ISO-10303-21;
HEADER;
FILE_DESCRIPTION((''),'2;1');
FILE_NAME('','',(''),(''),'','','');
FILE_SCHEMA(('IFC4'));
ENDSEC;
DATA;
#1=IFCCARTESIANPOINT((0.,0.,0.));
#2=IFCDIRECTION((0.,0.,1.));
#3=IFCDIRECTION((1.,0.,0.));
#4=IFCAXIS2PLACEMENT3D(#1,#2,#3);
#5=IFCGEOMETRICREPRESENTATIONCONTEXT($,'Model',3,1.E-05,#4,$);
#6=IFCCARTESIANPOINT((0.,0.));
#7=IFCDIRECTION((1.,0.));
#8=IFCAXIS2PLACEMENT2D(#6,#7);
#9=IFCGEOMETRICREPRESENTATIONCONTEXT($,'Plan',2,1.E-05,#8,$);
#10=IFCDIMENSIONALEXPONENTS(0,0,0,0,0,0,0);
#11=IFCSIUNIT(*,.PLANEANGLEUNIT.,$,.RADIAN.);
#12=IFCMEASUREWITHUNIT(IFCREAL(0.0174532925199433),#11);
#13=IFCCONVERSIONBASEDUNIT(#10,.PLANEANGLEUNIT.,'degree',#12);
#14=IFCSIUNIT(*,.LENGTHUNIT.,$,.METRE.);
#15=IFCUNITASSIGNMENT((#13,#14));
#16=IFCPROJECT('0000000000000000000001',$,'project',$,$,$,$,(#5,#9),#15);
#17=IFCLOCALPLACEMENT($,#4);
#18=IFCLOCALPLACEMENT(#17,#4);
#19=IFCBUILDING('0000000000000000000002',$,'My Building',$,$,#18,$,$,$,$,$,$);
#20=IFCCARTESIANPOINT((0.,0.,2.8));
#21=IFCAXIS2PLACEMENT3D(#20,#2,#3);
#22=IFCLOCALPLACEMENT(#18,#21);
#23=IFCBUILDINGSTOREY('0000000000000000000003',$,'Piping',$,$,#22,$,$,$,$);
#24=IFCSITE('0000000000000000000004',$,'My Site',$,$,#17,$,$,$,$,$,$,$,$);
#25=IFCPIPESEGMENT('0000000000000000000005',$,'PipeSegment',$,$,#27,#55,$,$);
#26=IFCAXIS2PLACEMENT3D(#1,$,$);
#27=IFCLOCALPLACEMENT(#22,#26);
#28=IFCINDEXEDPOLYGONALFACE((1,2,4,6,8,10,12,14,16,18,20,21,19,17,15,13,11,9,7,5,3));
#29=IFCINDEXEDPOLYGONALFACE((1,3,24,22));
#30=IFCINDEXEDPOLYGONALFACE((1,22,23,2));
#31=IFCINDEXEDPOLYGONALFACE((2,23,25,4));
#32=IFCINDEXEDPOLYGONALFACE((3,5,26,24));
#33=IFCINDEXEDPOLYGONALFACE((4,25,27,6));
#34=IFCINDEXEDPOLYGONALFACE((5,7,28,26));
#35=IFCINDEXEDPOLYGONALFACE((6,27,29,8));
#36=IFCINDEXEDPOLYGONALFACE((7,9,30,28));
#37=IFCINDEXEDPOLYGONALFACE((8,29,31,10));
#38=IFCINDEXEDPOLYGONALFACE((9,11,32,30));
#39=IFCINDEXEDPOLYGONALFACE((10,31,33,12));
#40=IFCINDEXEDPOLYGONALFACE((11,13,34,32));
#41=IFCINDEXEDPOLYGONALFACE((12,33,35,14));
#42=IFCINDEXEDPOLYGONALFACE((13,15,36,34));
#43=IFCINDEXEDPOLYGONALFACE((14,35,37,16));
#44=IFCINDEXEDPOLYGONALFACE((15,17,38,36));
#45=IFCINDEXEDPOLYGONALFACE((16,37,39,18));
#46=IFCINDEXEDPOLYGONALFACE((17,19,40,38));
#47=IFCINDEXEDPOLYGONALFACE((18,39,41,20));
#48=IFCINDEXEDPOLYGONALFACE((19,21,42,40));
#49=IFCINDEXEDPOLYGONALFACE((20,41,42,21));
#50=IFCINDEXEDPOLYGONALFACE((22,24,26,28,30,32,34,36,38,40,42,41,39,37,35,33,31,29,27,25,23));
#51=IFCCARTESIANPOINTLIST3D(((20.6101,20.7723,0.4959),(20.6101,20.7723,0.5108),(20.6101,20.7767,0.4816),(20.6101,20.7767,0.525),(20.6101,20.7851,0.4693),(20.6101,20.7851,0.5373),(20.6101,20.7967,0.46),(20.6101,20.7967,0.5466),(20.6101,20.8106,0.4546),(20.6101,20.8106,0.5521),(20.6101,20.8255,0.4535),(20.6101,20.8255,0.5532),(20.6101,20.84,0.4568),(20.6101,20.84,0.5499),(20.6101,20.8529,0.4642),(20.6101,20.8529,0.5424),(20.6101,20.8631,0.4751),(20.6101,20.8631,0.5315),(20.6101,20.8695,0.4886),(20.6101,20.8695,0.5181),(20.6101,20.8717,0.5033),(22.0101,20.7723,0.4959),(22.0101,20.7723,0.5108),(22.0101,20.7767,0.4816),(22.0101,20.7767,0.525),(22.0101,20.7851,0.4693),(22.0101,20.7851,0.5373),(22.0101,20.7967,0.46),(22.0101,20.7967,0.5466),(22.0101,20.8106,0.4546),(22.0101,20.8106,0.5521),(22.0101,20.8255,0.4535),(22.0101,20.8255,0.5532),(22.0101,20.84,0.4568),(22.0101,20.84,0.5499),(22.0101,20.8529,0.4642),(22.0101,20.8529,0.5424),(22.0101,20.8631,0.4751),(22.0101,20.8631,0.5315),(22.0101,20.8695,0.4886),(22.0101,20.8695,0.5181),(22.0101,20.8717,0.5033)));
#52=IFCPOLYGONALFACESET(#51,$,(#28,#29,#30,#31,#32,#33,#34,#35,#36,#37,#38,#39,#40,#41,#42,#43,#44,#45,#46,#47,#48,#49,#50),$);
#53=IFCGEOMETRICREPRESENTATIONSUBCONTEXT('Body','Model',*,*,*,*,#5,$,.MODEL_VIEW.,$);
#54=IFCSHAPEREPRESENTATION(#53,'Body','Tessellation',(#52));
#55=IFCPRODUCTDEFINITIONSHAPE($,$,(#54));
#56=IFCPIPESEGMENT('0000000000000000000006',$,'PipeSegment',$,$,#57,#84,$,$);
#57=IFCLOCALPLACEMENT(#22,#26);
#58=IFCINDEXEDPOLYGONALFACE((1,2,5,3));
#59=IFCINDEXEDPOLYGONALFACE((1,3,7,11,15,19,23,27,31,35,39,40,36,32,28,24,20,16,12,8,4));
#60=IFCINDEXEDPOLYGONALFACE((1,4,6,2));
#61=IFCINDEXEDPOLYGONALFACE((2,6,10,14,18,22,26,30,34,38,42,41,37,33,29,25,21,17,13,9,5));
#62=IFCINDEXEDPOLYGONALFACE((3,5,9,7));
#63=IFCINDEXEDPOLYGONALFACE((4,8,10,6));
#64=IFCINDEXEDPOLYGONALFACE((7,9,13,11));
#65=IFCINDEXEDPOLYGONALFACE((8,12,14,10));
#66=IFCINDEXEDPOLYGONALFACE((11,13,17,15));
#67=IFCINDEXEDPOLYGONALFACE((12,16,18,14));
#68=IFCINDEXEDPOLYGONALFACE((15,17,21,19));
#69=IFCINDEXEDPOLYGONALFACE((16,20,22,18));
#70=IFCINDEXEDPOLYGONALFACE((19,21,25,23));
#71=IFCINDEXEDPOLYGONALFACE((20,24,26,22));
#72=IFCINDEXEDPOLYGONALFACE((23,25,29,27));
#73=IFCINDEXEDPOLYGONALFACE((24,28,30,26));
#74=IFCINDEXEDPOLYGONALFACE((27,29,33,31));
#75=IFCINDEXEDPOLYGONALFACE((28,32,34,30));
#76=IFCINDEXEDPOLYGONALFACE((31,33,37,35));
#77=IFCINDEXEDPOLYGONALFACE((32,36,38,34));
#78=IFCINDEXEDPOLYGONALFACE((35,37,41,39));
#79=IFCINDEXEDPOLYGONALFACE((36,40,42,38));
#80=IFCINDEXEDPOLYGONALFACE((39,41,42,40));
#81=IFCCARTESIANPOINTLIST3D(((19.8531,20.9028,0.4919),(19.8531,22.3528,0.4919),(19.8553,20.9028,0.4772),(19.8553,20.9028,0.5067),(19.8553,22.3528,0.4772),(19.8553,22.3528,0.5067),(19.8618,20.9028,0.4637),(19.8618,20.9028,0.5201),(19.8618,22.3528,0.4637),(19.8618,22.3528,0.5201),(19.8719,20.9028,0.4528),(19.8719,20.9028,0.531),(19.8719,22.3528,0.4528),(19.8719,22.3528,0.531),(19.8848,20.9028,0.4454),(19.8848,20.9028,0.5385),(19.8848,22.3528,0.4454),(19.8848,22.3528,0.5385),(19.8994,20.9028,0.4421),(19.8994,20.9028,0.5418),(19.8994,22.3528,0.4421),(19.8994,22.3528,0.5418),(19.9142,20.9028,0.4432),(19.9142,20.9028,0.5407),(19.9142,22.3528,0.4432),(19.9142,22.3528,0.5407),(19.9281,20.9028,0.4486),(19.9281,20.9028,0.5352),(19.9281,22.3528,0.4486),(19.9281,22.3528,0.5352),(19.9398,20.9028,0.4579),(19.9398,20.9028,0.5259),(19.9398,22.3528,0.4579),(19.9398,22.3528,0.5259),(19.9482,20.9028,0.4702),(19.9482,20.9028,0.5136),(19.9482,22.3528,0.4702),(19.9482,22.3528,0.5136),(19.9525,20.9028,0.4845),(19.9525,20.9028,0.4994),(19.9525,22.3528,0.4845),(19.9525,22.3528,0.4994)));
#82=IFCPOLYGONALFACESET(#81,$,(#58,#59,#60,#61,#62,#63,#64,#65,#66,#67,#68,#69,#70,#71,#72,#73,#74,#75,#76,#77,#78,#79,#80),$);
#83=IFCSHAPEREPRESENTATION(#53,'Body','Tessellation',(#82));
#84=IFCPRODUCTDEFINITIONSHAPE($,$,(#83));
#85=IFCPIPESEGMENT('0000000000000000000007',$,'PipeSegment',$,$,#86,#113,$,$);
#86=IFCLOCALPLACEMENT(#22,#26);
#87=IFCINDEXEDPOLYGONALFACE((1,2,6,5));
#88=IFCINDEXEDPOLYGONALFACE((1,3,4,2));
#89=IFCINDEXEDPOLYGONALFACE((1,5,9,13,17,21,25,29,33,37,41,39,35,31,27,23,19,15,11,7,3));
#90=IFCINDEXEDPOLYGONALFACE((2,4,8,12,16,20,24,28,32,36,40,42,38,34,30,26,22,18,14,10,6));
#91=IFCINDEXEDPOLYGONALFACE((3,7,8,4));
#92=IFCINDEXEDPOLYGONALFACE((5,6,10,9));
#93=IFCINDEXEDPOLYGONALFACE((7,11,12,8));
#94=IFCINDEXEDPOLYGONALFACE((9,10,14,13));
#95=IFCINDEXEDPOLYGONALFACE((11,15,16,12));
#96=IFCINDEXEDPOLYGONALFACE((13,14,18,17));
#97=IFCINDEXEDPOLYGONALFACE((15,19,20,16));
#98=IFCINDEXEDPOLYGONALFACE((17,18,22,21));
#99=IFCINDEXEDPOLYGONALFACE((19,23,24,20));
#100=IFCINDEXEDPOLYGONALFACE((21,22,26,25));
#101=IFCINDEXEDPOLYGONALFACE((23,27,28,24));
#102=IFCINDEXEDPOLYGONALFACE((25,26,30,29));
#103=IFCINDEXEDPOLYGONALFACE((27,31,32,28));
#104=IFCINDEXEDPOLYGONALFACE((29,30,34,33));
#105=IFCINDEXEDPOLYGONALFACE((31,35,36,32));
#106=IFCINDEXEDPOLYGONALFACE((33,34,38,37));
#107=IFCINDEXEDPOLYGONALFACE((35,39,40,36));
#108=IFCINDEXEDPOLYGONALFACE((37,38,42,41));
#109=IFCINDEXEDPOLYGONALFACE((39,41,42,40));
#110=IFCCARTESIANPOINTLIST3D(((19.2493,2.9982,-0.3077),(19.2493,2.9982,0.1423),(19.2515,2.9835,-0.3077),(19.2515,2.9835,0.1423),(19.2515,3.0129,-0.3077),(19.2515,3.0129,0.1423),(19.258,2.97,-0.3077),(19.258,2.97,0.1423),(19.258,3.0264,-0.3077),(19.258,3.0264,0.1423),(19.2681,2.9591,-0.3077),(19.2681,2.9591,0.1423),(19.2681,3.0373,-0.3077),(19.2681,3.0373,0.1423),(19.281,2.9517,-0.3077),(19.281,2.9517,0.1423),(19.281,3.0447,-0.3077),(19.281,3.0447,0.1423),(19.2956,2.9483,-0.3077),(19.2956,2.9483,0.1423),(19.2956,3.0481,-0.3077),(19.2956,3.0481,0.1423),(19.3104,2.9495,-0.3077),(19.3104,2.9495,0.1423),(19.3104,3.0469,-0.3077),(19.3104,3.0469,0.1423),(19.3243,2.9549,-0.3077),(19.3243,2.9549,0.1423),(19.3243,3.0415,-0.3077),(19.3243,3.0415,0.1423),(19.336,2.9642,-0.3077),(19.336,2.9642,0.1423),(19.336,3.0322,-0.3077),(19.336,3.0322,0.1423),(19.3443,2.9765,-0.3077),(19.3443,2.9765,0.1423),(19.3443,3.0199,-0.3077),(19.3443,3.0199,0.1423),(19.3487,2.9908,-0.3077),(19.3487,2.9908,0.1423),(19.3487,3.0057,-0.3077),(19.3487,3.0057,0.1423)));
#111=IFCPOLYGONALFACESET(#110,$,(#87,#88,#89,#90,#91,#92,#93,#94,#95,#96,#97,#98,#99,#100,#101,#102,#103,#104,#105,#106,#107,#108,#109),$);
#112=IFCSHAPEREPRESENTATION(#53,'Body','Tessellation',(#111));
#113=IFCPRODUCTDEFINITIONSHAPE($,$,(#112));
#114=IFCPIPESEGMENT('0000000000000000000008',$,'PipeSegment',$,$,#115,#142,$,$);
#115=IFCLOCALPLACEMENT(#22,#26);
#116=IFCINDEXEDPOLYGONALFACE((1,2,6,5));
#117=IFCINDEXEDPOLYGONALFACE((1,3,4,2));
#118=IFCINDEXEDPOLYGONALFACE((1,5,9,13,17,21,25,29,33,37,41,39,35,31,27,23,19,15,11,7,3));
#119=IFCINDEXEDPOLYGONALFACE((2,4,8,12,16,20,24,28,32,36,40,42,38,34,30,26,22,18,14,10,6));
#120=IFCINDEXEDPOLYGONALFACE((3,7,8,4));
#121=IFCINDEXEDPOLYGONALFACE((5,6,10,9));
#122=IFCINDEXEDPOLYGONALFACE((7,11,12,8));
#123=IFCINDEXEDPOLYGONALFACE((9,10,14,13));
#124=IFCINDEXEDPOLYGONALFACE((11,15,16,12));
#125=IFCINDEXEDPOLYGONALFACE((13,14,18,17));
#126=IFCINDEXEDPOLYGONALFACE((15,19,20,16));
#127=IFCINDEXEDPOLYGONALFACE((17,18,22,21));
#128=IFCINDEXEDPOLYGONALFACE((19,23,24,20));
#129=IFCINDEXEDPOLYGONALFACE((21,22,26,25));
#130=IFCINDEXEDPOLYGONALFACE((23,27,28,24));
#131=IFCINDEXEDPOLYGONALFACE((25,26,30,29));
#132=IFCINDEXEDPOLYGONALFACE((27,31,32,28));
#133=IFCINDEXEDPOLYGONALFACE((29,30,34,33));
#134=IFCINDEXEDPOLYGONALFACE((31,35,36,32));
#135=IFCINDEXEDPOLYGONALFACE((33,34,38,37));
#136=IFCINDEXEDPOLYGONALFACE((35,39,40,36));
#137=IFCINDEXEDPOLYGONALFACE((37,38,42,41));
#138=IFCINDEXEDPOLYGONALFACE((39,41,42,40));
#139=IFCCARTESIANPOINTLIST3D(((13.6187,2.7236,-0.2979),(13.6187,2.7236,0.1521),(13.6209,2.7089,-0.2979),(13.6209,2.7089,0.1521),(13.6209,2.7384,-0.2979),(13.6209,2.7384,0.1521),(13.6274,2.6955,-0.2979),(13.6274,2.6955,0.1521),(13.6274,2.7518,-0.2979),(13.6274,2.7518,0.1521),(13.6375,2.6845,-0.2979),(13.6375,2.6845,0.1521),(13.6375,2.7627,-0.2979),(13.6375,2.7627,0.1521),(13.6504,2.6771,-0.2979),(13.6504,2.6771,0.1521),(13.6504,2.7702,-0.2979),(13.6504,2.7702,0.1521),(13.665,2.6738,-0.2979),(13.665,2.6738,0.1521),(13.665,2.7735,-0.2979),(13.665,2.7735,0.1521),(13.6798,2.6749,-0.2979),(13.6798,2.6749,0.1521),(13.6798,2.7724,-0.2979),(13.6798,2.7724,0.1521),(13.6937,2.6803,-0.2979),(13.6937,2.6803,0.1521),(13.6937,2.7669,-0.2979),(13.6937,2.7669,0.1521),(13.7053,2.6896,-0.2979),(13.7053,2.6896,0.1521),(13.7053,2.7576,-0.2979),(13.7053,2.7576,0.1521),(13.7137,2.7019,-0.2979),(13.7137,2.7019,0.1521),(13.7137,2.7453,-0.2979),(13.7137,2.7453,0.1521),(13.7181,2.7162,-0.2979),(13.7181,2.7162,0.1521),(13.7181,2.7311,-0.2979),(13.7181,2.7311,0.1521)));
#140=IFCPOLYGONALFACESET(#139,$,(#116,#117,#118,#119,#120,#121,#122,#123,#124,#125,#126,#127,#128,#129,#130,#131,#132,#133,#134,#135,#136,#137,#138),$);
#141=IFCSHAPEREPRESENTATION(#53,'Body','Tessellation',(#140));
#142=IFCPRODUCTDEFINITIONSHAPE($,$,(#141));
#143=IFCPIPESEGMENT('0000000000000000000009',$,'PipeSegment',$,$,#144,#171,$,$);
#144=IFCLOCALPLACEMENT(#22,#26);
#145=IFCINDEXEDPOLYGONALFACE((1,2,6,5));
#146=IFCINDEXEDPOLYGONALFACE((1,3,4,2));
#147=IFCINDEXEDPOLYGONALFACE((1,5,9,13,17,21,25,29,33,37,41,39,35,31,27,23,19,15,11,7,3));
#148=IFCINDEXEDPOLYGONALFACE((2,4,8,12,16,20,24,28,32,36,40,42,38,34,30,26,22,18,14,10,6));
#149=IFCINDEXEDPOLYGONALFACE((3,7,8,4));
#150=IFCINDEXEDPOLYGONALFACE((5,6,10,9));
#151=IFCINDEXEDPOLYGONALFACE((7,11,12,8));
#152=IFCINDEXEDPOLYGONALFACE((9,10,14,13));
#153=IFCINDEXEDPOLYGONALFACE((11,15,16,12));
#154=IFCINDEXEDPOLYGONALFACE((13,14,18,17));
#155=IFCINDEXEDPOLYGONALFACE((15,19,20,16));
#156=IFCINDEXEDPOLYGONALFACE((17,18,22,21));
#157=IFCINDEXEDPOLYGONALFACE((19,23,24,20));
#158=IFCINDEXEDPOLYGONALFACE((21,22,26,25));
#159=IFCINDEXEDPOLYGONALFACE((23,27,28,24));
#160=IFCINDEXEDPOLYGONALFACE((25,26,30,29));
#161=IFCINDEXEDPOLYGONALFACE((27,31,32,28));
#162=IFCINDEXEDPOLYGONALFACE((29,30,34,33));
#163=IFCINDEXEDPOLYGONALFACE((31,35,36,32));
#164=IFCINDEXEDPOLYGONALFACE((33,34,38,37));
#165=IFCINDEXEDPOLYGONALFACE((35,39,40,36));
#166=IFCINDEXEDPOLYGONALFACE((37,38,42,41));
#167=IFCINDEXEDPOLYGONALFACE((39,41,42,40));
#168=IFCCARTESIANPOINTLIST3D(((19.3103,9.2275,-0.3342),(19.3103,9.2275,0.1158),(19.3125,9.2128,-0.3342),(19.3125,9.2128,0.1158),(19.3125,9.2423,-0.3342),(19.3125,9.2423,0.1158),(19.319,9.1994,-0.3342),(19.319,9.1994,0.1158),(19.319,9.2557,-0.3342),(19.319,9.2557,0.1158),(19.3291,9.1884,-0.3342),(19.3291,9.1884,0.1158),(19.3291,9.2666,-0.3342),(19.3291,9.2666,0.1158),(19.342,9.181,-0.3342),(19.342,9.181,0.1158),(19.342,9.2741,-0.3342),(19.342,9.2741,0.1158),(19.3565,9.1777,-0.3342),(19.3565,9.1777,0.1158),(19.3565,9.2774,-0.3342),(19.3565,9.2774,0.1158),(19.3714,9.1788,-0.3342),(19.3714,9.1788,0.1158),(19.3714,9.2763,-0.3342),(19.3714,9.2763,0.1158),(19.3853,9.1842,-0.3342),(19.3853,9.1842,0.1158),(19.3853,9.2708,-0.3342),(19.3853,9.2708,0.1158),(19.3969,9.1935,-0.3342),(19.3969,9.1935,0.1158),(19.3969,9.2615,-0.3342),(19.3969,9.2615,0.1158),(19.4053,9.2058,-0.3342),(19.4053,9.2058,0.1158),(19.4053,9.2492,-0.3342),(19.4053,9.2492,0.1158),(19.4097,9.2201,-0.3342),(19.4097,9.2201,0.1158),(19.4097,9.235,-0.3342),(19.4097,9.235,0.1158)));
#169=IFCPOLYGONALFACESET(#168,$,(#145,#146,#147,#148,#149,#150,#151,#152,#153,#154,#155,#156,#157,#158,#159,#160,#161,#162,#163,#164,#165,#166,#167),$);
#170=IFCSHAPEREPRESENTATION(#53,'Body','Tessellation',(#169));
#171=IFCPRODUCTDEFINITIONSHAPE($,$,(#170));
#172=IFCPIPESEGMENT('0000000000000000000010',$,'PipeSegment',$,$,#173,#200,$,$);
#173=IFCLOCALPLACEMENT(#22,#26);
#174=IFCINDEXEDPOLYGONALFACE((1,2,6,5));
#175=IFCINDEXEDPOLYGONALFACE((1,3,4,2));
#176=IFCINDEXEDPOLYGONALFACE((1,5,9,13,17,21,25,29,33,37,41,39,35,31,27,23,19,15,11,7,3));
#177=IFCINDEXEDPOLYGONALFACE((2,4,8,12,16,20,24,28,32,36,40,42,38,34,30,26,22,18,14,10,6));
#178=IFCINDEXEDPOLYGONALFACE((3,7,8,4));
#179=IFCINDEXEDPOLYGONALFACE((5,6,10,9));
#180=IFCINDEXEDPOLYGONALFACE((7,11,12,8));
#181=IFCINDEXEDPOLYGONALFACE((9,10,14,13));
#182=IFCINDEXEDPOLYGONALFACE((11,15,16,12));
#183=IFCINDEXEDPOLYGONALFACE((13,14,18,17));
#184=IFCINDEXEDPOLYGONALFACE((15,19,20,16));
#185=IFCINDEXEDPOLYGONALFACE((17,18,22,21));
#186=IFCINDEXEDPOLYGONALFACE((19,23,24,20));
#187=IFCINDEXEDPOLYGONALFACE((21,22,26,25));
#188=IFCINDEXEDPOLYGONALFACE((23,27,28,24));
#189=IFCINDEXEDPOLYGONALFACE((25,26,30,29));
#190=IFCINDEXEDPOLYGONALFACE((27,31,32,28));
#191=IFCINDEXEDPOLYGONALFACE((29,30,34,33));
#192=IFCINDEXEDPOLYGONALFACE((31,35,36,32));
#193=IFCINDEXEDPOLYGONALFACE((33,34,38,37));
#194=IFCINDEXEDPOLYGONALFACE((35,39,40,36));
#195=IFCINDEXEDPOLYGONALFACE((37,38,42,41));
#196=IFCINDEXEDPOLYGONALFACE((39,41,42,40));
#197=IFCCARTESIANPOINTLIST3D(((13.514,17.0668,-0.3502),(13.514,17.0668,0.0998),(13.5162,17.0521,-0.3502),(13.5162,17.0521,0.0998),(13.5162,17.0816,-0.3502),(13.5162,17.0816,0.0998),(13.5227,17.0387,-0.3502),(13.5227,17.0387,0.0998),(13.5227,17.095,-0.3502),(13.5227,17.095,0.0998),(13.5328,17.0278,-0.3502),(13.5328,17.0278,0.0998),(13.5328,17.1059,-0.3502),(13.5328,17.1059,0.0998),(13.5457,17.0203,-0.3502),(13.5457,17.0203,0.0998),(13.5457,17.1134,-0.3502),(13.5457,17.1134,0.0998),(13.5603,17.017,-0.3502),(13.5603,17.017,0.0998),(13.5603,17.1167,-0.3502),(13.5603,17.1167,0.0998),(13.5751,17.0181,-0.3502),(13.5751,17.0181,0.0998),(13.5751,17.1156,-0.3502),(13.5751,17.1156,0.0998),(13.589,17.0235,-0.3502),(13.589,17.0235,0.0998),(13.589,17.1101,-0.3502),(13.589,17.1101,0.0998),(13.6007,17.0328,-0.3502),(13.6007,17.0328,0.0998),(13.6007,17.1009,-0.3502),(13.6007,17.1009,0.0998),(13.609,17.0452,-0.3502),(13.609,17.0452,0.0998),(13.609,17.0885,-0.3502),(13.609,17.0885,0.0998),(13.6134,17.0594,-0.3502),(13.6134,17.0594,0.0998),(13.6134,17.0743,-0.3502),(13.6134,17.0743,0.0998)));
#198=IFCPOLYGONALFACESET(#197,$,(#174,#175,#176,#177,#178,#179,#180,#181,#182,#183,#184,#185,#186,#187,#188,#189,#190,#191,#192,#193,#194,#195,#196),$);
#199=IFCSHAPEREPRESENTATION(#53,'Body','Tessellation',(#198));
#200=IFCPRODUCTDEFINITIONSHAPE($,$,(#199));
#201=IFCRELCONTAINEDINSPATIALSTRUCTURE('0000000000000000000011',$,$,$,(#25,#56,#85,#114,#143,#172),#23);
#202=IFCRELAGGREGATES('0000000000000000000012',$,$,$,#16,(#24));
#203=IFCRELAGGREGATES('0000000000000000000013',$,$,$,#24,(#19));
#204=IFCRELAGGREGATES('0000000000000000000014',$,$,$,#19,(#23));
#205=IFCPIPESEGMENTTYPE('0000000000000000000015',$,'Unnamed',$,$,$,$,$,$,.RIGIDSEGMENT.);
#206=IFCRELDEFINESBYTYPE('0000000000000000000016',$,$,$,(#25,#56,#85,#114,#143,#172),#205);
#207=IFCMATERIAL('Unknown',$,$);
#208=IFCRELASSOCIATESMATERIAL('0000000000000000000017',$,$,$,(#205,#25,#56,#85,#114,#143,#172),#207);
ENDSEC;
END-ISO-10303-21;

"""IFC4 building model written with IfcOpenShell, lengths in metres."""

from ifc_helpers import new_model, entity, si_unit, converted_unit, frame, origin_with_axes, origin_2d_with_axis, place, context, subcontext, project, spatial, circle, extrude, material, material_profile, profile_set, profile_usage, type_object, element, save


model = new_model("IFC4")

# Units and contexts
model_context = context("Model", 3, precision=1e-05, world=origin_with_axes())
plan_context = context("Plan", 2, precision=1e-05, world=origin_2d_with_axis())
body_context = subcontext(model_context, "Body", "Model", "MODEL_VIEW")
ifc_project = project(units=[converted_unit("PLANEANGLEUNIT", "degree", entity("IfcReal", 0.0174532925199433), si_unit("PLANEANGLEUNIT", "RADIAN"), dimensions=[0, 0, 0, 0, 0, 0, 0]), si_unit("LENGTHUNIT", "METRE")], contexts=[model_context, plan_context])

# Site, building, storey
site_placement = place(None, origin_with_axes())
site = spatial("IfcSite", under=ifc_project, at=site_placement, Name="My Site")
building_placement = place(site_placement, origin_with_axes())
building = spatial("IfcBuilding", under=site, at=building_placement, Name="My Building")
storey_placement = place(building_placement, frame((0.0, 0.0, 2.8), z_axis=(0.0, 0.0, 1.0), x_axis=(1.0, 0.0, 0.0)))
storey = spatial("IfcBuildingStorey", under=building, at=storey_placement, Name="Piping")

# Pipe segments
ifc_material = material(Name="Unknown")
ifc_material_profile_1 = material_profile(ifc_material, circle(Radius=0.05))
ifc_profile_set_1 = profile_set([ifc_material_profile_1])
pipe_segment_type = type_object("IfcPipeSegmentType", Name="Unnamed", PredefinedType="RIGIDSEGMENT", material=ifc_profile_set_1)
ifc_profile_usage_1 = profile_usage(ifc_profile_set_1, cardinal=5)
pipe_segment_1_placement = place(storey_placement, frame((20.6101, 20.8217, 0.5033), z_axis=(1.0, 0.0, 0.0), x_axis=(0.0, 1.0, 0.0)))
element("IfcPipeSegment", 1, at=pipe_segment_1_placement, inside=storey, type_object=pipe_segment_type, material=ifc_profile_usage_1, Name="PipeSegment", context=body_context, shape_type="SweptSolid", body=[
    extrude(circle(Radius=0.05), origin_with_axes(), (0.0, 0.0, 1.0), 1.4),
])
ifc_profile_usage_2 = profile_usage(ifc_profile_set_1, cardinal=5)
pipe_segment_2_placement = place(storey_placement, frame((19.9031, 20.9028, 0.4919), z_axis=(0.0, 1.0, 0.0), x_axis=(-1.0, 0.0, 0.0)))
element("IfcPipeSegment", 2, at=pipe_segment_2_placement, inside=storey, type_object=pipe_segment_type, material=ifc_profile_usage_2, Name="PipeSegment", context=body_context, shape_type="SweptSolid", body=[
    extrude(circle(Radius=0.05), origin_with_axes(), (0.0, 0.0, 1.0), 1.45),
])
ifc_profile_usage_3 = profile_usage(ifc_profile_set_1, cardinal=5)
pipe_segment_3_placement = place(storey_placement, frame((19.2993, 2.9982, 0.1423), z_axis=(0.0, 0.0, -1.0), x_axis=(-1.0, 0.0, 0.0)))
element("IfcPipeSegment", 3, at=pipe_segment_3_placement, inside=storey, type_object=pipe_segment_type, material=ifc_profile_usage_3, Name="PipeSegment", context=body_context, shape_type="SweptSolid", body=[
    extrude(circle(Radius=0.05), origin_with_axes(), (0.0, 0.0, 1.0), 0.45),
])
ifc_profile_usage_4 = profile_usage(ifc_profile_set_1, cardinal=5)
pipe_segment_4_placement = place(storey_placement, frame((13.6687, 2.7236, 0.1521), z_axis=(0.0, 0.0, -1.0), x_axis=(-1.0, 0.0, 0.0)))
element("IfcPipeSegment", 4, at=pipe_segment_4_placement, inside=storey, type_object=pipe_segment_type, material=ifc_profile_usage_4, Name="PipeSegment", context=body_context, shape_type="SweptSolid", body=[
    extrude(circle(Radius=0.05), origin_with_axes(), (0.0, 0.0, 1.0), 0.45),
])
ifc_profile_usage_5 = profile_usage(ifc_profile_set_1, cardinal=5)
pipe_segment_5_placement = place(storey_placement, frame((19.3603, 9.2275, 0.1158), z_axis=(0.0, 0.0, -1.0), x_axis=(-1.0, 0.0, 0.0)))
element("IfcPipeSegment", 5, at=pipe_segment_5_placement, inside=storey, type_object=pipe_segment_type, material=ifc_profile_usage_5, Name="PipeSegment", context=body_context, shape_type="SweptSolid", body=[
    extrude(circle(Radius=0.05), origin_with_axes(), (0.0, 0.0, 1.0), 0.45),
])
ifc_profile_usage_6 = profile_usage(ifc_profile_set_1, cardinal=5)
pipe_segment_6_placement = place(storey_placement, frame((13.564, 17.0668, 0.0998), z_axis=(0.0, 0.0, -1.0), x_axis=(-1.0, 0.0, 0.0)))
element("IfcPipeSegment", 6, at=pipe_segment_6_placement, inside=storey, type_object=pipe_segment_type, material=ifc_profile_usage_6, Name="PipeSegment", context=body_context, shape_type="SweptSolid", body=[
    extrude(circle(Radius=0.05), origin_with_axes(), (0.0, 0.0, 1.0), 0.45),
])

save(model, "model.ifc")
